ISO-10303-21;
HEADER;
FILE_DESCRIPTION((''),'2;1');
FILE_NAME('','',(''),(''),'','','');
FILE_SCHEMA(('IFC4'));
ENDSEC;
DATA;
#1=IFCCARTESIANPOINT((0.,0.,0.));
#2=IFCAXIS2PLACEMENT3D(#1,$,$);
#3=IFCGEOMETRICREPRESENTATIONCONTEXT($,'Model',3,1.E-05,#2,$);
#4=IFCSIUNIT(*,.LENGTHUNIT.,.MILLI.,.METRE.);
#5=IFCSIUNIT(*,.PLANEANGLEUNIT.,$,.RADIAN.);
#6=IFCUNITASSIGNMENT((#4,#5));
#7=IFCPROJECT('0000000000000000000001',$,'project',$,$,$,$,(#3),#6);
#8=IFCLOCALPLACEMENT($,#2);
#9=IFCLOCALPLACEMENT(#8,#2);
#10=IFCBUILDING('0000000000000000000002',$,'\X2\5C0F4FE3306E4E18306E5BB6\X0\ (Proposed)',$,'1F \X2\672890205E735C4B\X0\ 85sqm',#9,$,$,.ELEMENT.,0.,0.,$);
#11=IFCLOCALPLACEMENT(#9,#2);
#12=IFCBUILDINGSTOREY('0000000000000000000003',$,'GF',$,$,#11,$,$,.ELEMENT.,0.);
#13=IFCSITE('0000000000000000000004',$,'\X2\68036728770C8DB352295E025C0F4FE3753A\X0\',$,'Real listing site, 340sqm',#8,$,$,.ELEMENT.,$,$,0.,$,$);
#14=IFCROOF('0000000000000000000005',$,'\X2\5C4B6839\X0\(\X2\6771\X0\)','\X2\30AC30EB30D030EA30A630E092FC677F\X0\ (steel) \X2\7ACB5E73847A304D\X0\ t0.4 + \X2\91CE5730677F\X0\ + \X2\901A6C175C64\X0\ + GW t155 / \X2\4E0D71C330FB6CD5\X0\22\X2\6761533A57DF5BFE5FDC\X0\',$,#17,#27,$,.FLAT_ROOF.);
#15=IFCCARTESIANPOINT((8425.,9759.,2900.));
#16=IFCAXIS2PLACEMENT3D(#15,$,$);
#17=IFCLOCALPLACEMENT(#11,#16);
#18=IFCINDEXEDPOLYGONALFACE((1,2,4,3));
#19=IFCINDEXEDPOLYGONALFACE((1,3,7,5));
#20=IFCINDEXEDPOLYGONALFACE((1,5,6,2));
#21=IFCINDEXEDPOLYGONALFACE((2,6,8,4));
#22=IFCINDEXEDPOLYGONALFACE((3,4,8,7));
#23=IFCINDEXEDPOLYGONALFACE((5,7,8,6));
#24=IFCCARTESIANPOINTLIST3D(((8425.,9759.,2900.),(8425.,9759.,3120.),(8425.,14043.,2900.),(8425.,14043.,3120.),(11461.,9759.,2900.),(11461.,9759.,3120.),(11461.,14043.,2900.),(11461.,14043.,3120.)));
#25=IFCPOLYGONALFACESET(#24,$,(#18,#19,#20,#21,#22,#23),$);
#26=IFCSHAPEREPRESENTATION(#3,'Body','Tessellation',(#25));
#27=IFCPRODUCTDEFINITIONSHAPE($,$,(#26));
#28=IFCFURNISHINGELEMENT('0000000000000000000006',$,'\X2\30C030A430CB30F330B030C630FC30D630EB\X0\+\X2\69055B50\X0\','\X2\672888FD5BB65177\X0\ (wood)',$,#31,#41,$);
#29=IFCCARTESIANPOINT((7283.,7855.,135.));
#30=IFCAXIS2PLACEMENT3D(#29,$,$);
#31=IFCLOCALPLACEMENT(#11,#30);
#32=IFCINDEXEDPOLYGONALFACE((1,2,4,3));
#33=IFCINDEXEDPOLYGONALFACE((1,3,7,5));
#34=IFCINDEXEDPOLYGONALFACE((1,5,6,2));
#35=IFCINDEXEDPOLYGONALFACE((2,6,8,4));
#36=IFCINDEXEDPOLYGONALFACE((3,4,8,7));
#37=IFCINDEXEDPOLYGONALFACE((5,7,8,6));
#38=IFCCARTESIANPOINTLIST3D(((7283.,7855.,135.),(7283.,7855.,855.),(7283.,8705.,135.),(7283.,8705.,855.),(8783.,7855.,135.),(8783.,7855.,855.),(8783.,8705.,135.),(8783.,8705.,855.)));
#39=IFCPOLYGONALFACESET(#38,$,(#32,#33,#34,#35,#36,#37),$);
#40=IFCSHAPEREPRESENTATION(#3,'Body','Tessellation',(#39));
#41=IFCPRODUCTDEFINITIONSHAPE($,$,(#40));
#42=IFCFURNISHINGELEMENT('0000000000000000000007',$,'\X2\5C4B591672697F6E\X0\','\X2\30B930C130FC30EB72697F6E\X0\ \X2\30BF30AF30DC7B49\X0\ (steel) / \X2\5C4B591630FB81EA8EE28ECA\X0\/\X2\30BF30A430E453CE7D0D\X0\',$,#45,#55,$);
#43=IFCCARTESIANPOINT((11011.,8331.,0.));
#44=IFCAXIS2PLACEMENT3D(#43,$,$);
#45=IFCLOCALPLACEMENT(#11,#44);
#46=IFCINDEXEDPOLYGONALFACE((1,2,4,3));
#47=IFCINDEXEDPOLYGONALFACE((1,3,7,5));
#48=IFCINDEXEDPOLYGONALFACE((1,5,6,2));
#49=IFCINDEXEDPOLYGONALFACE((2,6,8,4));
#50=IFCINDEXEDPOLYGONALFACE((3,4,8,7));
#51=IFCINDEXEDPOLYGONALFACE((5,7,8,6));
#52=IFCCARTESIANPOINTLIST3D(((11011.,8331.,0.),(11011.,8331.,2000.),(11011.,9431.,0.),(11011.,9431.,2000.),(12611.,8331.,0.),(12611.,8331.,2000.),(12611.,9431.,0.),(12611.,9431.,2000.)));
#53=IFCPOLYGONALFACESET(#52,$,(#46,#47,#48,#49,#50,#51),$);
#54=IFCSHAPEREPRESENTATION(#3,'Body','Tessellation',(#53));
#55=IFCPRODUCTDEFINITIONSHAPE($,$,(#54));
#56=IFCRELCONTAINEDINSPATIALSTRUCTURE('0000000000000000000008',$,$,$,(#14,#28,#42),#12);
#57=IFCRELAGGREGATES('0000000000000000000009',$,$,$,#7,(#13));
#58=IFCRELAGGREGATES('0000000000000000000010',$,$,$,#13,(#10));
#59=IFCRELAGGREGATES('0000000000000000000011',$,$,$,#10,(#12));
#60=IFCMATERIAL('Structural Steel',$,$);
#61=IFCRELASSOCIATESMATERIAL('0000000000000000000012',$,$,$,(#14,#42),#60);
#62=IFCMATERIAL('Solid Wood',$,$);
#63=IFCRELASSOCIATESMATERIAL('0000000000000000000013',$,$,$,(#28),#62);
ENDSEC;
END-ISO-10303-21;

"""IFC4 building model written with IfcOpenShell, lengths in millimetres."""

from ifc_helpers import new_model, si_unit, frame, frame_2d, origin, place, context, project, spatial, rectangle, extrude, material, element, save


model = new_model("IFC4")

# Units and contexts
model_context = context("Model", 3, precision=1e-05, world=origin())
ifc_project = project(units=[si_unit("LENGTHUNIT", "METRE", prefix="MILLI"), si_unit("PLANEANGLEUNIT", "RADIAN")], contexts=[model_context])

# Site, building, storey
site_placement = place(None, origin())
site = spatial("IfcSite", under=ifc_project, at=site_placement, Name="栃木県足利市小俣町", ObjectType="Real listing site, 340sqm", CompositionType="ELEMENT", RefElevation=0.0)
building_placement = place(site_placement, origin())
building = spatial("IfcBuilding", under=site, at=building_placement, Name="小俣の丘の家 (Proposed)", ObjectType="1F 木造平屋 85sqm", CompositionType="ELEMENT", ElevationOfRefHeight=0.0, ElevationOfTerrain=0.0)
storey_placement = place(building_placement, origin())
storey = spatial("IfcBuildingStorey", under=building, at=storey_placement, Name="GF", CompositionType="ELEMENT", Elevation=0.0)

# Shared definitions
ifc_material_1 = material(Name="Solid Wood")

# Roof
ifc_material_2 = material(Name="Structural Steel")
roof_1_placement = place(storey_placement, frame((8425.0, 9759.0, 2900.0)))
element("IfcRoof", 1, at=roof_1_placement, inside=storey, material=ifc_material_2, Name="屋根(東)", Description="ガルバリウム鋼板 (steel) 立平葺き t0.4 + 野地板 + 通気層 + GW t155 / 不燃・法22条区域対応", PredefinedType="FLAT_ROOF", context=model_context, shape_type="SweptSolid", body=[
    extrude(rectangle(XDim=3036.0, YDim=4284.0, at=frame_2d((1518.0, 2142.0))), frame((8425.0, 9759.0, 2900.0)), (0.0, 0.0, 1.0), 220.0),
])

# Furnishing elements
furnishing_1_placement = place(storey_placement, frame((7283.0, 7855.0, 135.0)))
element("IfcFurnishingElement", 2, at=furnishing_1_placement, inside=storey, material=ifc_material_1, Name="ダイニングテーブル+椅子", Description="木製家具 (wood)", context=model_context, shape_type="SweptSolid", body=[
    extrude(rectangle(XDim=1500.0, YDim=850.0, at=frame_2d((750.0, 425.0))), frame((7283.0, 7855.0, 135.0)), (0.0, 0.0, 1.0), 720.0),
])
furnishing_2_placement = place(storey_placement, frame((11011.0, 8331.0, 0.0)))
element("IfcFurnishingElement", 3, at=furnishing_2_placement, inside=storey, material=ifc_material_2, Name="屋外物置", Description="スチール物置 タクボ等 (steel) / 屋外・自転車/タイヤ収納", context=model_context, shape_type="SweptSolid", body=[
    extrude(rectangle(XDim=1600.0, YDim=1100.0, at=frame_2d((800.0, 550.0))), frame((11011.0, 8331.0, 0.0)), (0.0, 0.0, 1.0), 2000.0),
])

save(model, "model.ifc")
